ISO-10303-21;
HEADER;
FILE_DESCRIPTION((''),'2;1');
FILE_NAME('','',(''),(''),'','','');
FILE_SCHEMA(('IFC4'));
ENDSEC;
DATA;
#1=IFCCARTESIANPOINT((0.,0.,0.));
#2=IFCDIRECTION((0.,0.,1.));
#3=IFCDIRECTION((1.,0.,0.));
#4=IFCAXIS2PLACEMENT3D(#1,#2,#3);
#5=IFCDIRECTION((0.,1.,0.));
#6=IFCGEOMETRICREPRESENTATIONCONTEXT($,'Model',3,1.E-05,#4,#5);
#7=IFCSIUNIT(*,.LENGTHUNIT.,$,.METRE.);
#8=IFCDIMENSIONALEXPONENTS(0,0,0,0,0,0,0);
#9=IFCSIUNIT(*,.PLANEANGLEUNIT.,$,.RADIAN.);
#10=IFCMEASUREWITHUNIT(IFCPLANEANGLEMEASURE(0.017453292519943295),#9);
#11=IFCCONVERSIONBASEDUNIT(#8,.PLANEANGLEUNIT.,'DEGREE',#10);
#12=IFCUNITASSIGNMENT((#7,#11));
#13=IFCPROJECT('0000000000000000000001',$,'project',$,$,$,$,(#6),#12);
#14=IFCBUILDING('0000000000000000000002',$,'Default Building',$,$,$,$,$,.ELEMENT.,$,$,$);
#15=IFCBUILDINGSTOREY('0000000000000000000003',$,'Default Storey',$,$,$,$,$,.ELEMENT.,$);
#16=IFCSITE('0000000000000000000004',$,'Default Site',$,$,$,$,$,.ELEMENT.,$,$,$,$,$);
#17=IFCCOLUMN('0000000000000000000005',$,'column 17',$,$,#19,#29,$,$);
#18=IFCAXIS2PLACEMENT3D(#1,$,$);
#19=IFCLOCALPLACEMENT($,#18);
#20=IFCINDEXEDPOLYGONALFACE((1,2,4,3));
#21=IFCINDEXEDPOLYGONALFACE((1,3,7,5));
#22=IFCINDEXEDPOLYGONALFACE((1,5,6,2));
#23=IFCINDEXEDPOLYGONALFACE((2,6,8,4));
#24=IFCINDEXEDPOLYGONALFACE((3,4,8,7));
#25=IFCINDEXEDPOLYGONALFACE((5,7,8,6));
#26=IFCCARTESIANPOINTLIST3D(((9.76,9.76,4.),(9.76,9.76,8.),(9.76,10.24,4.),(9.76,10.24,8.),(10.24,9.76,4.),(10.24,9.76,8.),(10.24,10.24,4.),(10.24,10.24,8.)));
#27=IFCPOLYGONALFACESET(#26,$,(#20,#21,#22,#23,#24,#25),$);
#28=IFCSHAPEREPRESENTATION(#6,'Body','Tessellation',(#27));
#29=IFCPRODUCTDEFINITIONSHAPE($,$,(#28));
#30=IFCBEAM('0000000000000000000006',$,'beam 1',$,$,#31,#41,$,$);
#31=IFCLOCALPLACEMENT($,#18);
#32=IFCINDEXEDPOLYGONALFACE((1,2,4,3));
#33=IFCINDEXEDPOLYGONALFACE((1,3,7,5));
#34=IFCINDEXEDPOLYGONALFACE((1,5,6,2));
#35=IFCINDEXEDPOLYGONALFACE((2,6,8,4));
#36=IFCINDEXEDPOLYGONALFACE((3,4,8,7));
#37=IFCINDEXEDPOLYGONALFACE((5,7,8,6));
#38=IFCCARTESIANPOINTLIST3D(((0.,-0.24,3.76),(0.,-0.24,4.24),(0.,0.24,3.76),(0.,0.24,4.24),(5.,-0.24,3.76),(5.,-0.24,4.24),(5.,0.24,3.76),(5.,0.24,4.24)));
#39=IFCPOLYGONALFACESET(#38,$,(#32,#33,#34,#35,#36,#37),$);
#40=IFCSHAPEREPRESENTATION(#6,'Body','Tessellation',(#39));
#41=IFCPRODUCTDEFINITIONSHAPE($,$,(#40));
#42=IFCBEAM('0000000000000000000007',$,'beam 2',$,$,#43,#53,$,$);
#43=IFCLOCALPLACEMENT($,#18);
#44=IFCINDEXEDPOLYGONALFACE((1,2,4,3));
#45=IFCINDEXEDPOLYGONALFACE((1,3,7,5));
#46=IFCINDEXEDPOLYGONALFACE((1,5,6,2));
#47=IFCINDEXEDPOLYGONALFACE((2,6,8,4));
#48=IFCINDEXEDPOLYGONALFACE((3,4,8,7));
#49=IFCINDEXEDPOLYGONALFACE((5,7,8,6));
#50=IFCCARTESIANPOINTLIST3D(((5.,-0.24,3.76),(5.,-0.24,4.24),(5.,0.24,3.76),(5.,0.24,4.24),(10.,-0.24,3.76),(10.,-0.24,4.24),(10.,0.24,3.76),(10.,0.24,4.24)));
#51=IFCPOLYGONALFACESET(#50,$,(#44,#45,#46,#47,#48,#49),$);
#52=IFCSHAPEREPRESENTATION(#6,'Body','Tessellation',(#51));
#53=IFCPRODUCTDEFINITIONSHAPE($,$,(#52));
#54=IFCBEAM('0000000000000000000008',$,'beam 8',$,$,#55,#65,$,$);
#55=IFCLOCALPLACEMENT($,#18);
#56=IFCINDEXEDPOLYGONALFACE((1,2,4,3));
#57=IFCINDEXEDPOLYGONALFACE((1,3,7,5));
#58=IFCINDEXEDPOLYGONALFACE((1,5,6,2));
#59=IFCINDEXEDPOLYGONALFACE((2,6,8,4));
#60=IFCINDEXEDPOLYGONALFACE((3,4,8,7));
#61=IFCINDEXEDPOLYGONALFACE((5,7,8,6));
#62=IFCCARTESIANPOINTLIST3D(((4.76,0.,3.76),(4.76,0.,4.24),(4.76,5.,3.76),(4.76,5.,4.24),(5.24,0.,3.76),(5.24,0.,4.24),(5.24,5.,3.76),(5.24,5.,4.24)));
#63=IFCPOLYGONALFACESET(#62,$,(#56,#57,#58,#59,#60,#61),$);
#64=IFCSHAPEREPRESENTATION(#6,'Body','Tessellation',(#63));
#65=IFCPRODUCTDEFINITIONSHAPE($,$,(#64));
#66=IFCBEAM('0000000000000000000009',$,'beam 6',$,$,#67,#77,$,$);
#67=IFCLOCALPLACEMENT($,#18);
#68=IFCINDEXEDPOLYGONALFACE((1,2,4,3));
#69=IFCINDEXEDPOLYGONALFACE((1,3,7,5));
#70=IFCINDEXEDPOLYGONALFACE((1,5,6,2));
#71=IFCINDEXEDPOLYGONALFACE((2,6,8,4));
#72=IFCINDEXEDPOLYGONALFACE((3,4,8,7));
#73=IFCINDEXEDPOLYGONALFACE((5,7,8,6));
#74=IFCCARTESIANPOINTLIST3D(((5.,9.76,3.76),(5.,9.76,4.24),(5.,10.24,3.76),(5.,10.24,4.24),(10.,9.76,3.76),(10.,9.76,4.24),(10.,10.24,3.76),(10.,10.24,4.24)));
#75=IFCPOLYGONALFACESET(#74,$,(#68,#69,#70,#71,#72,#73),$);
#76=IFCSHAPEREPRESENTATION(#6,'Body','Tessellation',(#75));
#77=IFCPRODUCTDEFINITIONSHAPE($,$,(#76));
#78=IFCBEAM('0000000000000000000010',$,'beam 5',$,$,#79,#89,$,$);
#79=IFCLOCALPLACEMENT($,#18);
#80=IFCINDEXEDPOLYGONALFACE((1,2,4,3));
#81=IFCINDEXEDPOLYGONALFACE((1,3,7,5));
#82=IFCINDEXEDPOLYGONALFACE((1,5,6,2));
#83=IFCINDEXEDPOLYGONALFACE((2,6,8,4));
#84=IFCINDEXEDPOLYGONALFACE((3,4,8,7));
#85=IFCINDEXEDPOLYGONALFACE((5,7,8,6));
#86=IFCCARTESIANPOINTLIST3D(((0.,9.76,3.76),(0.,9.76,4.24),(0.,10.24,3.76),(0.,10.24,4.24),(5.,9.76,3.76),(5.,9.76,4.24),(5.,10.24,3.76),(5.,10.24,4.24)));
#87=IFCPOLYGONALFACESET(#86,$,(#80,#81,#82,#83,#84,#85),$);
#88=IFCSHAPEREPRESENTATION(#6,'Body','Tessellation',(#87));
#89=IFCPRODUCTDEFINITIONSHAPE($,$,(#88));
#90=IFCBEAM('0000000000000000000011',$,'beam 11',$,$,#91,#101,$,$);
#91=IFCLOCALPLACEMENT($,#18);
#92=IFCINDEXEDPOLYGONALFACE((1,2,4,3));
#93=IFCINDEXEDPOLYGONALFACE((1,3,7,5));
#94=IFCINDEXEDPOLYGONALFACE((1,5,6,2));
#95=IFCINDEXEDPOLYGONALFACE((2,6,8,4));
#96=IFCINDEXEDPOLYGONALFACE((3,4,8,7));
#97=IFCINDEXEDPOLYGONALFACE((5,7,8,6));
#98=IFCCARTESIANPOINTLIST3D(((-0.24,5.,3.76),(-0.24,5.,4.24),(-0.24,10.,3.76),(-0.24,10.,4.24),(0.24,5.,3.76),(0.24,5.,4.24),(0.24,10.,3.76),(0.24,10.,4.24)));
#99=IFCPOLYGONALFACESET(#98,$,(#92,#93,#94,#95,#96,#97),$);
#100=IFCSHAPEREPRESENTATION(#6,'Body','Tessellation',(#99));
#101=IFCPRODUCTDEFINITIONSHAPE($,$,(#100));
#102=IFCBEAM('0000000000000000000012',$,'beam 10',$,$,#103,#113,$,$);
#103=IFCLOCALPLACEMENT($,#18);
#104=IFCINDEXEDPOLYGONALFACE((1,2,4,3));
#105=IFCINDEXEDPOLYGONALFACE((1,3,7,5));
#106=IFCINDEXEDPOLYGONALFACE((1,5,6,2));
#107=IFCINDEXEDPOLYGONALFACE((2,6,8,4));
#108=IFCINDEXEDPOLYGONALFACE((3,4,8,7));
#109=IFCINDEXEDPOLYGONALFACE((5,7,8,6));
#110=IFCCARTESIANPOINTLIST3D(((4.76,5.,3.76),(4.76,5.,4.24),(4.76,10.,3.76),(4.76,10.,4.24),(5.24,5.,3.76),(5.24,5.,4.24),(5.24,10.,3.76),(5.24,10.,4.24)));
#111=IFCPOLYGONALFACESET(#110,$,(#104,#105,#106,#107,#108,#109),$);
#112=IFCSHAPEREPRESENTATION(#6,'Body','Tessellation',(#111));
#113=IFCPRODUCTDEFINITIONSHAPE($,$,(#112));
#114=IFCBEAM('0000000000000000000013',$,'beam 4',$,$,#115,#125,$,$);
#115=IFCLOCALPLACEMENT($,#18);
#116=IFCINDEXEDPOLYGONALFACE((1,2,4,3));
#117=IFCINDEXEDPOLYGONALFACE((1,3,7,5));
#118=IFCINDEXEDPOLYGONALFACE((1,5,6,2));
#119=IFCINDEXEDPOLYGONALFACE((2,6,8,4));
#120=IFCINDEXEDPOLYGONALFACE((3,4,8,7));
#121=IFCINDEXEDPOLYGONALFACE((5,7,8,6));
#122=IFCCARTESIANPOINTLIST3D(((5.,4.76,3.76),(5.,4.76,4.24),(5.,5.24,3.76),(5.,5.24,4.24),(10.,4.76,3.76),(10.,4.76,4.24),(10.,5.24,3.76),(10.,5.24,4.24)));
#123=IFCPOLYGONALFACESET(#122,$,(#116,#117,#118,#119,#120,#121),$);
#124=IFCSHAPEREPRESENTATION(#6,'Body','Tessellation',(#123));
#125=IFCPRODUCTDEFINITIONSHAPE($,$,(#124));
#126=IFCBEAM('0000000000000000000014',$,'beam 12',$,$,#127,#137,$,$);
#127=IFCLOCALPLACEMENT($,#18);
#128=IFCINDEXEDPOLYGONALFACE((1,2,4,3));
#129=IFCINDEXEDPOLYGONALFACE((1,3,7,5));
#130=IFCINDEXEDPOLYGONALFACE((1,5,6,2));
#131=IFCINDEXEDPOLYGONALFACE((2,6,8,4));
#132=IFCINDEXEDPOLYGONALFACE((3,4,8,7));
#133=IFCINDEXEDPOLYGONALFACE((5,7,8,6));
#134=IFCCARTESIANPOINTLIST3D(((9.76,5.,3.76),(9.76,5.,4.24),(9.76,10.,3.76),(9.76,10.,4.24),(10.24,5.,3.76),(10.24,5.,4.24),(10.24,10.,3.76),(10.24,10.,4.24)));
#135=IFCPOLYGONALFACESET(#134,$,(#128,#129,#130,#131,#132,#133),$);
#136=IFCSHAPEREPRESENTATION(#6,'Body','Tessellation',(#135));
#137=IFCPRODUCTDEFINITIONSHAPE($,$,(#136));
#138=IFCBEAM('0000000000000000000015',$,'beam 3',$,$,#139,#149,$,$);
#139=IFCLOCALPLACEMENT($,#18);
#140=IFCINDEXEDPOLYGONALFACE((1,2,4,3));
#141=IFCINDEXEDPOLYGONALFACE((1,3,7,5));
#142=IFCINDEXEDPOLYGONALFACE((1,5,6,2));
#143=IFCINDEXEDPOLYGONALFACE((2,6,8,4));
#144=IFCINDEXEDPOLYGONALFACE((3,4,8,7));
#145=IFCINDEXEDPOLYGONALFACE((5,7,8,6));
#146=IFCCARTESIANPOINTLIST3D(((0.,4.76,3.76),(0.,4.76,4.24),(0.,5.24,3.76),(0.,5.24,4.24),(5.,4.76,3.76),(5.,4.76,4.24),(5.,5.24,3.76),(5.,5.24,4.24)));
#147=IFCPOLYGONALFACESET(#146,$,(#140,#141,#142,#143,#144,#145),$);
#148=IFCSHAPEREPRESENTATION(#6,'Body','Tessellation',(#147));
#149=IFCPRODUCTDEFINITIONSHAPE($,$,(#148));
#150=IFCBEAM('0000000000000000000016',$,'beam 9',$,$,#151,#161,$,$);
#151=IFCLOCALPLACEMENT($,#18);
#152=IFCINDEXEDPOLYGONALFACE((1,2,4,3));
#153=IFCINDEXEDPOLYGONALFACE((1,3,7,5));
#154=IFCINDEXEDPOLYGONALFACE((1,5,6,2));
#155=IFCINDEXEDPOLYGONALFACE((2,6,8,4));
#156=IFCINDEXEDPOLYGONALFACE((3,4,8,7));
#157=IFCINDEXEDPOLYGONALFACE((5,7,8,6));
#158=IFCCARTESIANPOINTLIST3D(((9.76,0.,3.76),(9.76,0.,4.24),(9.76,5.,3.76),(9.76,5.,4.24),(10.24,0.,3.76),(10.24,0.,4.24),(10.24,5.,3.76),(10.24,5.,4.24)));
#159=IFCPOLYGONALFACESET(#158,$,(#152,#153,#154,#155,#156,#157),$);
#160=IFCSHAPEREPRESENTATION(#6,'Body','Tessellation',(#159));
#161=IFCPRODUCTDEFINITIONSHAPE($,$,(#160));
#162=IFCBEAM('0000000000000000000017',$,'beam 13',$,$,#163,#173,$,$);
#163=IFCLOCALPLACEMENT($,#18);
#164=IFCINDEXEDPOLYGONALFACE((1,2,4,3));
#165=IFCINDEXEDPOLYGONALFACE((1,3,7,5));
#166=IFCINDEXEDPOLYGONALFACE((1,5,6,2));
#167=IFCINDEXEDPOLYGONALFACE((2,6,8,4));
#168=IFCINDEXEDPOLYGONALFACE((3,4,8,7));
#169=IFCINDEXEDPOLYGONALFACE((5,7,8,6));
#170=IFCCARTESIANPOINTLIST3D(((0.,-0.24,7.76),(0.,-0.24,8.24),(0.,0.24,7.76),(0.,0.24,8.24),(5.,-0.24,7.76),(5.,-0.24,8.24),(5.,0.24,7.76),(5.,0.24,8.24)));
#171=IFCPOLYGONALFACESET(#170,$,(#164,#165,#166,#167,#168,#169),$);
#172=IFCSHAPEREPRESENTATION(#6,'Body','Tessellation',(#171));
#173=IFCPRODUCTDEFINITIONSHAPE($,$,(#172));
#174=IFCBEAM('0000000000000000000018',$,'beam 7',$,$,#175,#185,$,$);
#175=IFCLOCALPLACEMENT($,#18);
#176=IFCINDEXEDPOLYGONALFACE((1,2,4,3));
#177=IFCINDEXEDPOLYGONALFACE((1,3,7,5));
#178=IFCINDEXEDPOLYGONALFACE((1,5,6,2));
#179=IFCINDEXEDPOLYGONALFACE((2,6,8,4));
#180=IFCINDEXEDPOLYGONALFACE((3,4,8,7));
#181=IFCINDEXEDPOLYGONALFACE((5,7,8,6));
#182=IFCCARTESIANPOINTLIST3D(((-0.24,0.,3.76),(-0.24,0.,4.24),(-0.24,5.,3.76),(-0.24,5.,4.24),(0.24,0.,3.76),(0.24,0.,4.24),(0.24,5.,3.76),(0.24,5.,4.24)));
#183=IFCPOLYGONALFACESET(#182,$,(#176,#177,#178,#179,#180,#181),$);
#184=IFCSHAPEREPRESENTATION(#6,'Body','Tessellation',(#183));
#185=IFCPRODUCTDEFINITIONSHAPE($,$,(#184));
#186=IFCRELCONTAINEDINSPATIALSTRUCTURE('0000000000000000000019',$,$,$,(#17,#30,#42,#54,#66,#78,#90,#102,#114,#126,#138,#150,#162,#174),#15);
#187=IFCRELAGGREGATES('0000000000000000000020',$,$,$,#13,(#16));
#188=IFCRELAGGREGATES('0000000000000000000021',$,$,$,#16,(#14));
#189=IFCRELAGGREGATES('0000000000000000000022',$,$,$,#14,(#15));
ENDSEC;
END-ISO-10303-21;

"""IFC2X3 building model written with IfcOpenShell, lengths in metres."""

from ifc_helpers import new_model, entity, si_unit, converted_unit, direction, frame, origin_with_axes, place, context, project, spatial, polyline, outline, extrude, element, save


model = new_model("IFC2X3")

# Units and contexts
model_context = context("Model", 3, precision=1e-05, world=origin_with_axes(), true_north=direction((0.0, 1.0, 0.0)))
ifc_project = project(units=[si_unit("LENGTHUNIT", "METRE"), converted_unit("PLANEANGLEUNIT", "DEGREE", entity("IfcPlaneAngleMeasure", 0.017453292519943295), si_unit("PLANEANGLEUNIT", "RADIAN"), dimensions=[0, 0, 0, 0, 0, 0, 0])], contexts=[model_context])

# Site, building, storey
site = spatial("IfcSite", under=ifc_project, Name="Default Site", CompositionType="ELEMENT")
building = spatial("IfcBuilding", under=site, Name="Default Building", CompositionType="ELEMENT")
storey = spatial("IfcBuildingStorey", under=building, Name="Default Storey", CompositionType="ELEMENT")

# Column
placement = place(None, origin_with_axes())
element("IfcColumn", 1, at=placement, inside=storey, Name="column 17", context=model_context, shape_type="SweptSolid", body=[
    extrude(outline(polyline([(-0.24, -0.24), (0.24, -0.24), (0.24, 0.24), (-0.24, 0.24), (-0.24, -0.24)])), frame((10.0, 10.0, 4.0), z_axis=(0.0, 0.0, 1.0), x_axis=(1.0, 0.0, 0.0)), (0.0, 0.0, 1.0), 4.0),
])

# Beams
element("IfcBeam", 2, at=placement, inside=storey, Name="beam 1", context=model_context, shape_type="SweptSolid", body=[
    extrude(outline(polyline([(0.24, -0.24), (0.24, 0.24), (-0.24, 0.24), (-0.24, -0.24), (0.24, -0.24)])), frame((0.0, 0.0, 4.0), z_axis=(1.0, 0.0, 0.0), x_axis=(0.0, 0.0, -1.0)), (0.0, 0.0, 1.0), 5.0),
])
element("IfcBeam", 3, at=placement, inside=storey, Name="beam 2", context=model_context, shape_type="SweptSolid", body=[
    extrude(outline(polyline([(0.24, -0.24), (0.24, 0.24), (-0.24, 0.24), (-0.24, -0.24), (0.24, -0.24)])), frame((5.0, 0.0, 4.0), z_axis=(1.0, 0.0, 0.0), x_axis=(0.0, 0.0, -1.0)), (0.0, 0.0, 1.0), 5.0),
])
element("IfcBeam", 4, at=placement, inside=storey, Name="beam 8", context=model_context, shape_type="SweptSolid", body=[
    extrude(outline(polyline([(0.24, -0.24), (0.24, 0.24), (-0.24, 0.24), (-0.24, -0.24), (0.24, -0.24)])), frame((5.0, 0.0, 4.0), z_axis=(0.0, 1.0, 0.0), x_axis=(0.0, 0.0, -1.0)), (0.0, 0.0, 1.0), 5.0),
])
element("IfcBeam", 5, at=placement, inside=storey, Name="beam 6", context=model_context, shape_type="SweptSolid", body=[
    extrude(outline(polyline([(0.24, -0.24), (0.24, 0.24), (-0.24, 0.24), (-0.24, -0.24), (0.24, -0.24)])), frame((5.0, 10.0, 4.0), z_axis=(1.0, 0.0, 0.0), x_axis=(0.0, 0.0, -1.0)), (0.0, 0.0, 1.0), 5.0),
])
element("IfcBeam", 6, at=placement, inside=storey, Name="beam 5", context=model_context, shape_type="SweptSolid", body=[
    extrude(outline(polyline([(0.24, -0.24), (0.24, 0.24), (-0.24, 0.24), (-0.24, -0.24), (0.24, -0.24)])), frame((0.0, 10.0, 4.0), z_axis=(1.0, 0.0, 0.0), x_axis=(0.0, 0.0, -1.0)), (0.0, 0.0, 1.0), 5.0),
])
element("IfcBeam", 7, at=placement, inside=storey, Name="beam 11", context=model_context, shape_type="SweptSolid", body=[
    extrude(outline(polyline([(0.24, -0.24), (0.24, 0.24), (-0.24, 0.24), (-0.24, -0.24), (0.24, -0.24)])), frame((0.0, 5.0, 4.0), z_axis=(0.0, 1.0, 0.0), x_axis=(0.0, 0.0, -1.0)), (0.0, 0.0, 1.0), 5.0),
])
element("IfcBeam", 8, at=placement, inside=storey, Name="beam 10", context=model_context, shape_type="SweptSolid", body=[
    extrude(outline(polyline([(0.24, -0.24), (0.24, 0.24), (-0.24, 0.24), (-0.24, -0.24), (0.24, -0.24)])), frame((5.0, 5.0, 4.0), z_axis=(0.0, 1.0, 0.0), x_axis=(0.0, 0.0, -1.0)), (0.0, 0.0, 1.0), 5.0),
])
element("IfcBeam", 9, at=placement, inside=storey, Name="beam 4", context=model_context, shape_type="SweptSolid", body=[
    extrude(outline(polyline([(0.24, -0.24), (0.24, 0.24), (-0.24, 0.24), (-0.24, -0.24), (0.24, -0.24)])), frame((5.0, 5.0, 4.0), z_axis=(1.0, 0.0, 0.0), x_axis=(0.0, 0.0, -1.0)), (0.0, 0.0, 1.0), 5.0),
])
element("IfcBeam", 10, at=placement, inside=storey, Name="beam 12", context=model_context, shape_type="SweptSolid", body=[
    extrude(outline(polyline([(0.24, -0.24), (0.24, 0.24), (-0.24, 0.24), (-0.24, -0.24), (0.24, -0.24)])), frame((10.0, 5.0, 4.0), z_axis=(0.0, 1.0, 0.0), x_axis=(0.0, 0.0, -1.0)), (0.0, 0.0, 1.0), 5.0),
])
element("IfcBeam", 11, at=placement, inside=storey, Name="beam 3", context=model_context, shape_type="SweptSolid", body=[
    extrude(outline(polyline([(0.24, -0.24), (0.24, 0.24), (-0.24, 0.24), (-0.24, -0.24), (0.24, -0.24)])), frame((0.0, 5.0, 4.0), z_axis=(1.0, 0.0, 0.0), x_axis=(0.0, 0.0, -1.0)), (0.0, 0.0, 1.0), 5.0),
])
element("IfcBeam", 12, at=placement, inside=storey, Name="beam 9", context=model_context, shape_type="SweptSolid", body=[
    extrude(outline(polyline([(0.24, -0.24), (0.24, 0.24), (-0.24, 0.24), (-0.24, -0.24), (0.24, -0.24)])), frame((10.0, 0.0, 4.0), z_axis=(0.0, 1.0, 0.0), x_axis=(0.0, 0.0, -1.0)), (0.0, 0.0, 1.0), 5.0),
])
element("IfcBeam", 13, at=placement, inside=storey, Name="beam 13", context=model_context, shape_type="SweptSolid", body=[
    extrude(outline(polyline([(0.24, -0.24), (0.24, 0.24), (-0.24, 0.24), (-0.24, -0.24), (0.24, -0.24)])), frame((0.0, 0.0, 8.0), z_axis=(1.0, 0.0, 0.0), x_axis=(0.0, 0.0, -1.0)), (0.0, 0.0, 1.0), 5.0),
])
element("IfcBeam", 14, at=placement, inside=storey, Name="beam 7", context=model_context, shape_type="SweptSolid", body=[
    extrude(outline(polyline([(0.24, -0.24), (0.24, 0.24), (-0.24, 0.24), (-0.24, -0.24), (0.24, -0.24)])), frame((0.0, 0.0, 4.0), z_axis=(0.0, 1.0, 0.0), x_axis=(0.0, 0.0, -1.0)), (0.0, 0.0, 1.0), 5.0),
])

save(model, "model.ifc")
